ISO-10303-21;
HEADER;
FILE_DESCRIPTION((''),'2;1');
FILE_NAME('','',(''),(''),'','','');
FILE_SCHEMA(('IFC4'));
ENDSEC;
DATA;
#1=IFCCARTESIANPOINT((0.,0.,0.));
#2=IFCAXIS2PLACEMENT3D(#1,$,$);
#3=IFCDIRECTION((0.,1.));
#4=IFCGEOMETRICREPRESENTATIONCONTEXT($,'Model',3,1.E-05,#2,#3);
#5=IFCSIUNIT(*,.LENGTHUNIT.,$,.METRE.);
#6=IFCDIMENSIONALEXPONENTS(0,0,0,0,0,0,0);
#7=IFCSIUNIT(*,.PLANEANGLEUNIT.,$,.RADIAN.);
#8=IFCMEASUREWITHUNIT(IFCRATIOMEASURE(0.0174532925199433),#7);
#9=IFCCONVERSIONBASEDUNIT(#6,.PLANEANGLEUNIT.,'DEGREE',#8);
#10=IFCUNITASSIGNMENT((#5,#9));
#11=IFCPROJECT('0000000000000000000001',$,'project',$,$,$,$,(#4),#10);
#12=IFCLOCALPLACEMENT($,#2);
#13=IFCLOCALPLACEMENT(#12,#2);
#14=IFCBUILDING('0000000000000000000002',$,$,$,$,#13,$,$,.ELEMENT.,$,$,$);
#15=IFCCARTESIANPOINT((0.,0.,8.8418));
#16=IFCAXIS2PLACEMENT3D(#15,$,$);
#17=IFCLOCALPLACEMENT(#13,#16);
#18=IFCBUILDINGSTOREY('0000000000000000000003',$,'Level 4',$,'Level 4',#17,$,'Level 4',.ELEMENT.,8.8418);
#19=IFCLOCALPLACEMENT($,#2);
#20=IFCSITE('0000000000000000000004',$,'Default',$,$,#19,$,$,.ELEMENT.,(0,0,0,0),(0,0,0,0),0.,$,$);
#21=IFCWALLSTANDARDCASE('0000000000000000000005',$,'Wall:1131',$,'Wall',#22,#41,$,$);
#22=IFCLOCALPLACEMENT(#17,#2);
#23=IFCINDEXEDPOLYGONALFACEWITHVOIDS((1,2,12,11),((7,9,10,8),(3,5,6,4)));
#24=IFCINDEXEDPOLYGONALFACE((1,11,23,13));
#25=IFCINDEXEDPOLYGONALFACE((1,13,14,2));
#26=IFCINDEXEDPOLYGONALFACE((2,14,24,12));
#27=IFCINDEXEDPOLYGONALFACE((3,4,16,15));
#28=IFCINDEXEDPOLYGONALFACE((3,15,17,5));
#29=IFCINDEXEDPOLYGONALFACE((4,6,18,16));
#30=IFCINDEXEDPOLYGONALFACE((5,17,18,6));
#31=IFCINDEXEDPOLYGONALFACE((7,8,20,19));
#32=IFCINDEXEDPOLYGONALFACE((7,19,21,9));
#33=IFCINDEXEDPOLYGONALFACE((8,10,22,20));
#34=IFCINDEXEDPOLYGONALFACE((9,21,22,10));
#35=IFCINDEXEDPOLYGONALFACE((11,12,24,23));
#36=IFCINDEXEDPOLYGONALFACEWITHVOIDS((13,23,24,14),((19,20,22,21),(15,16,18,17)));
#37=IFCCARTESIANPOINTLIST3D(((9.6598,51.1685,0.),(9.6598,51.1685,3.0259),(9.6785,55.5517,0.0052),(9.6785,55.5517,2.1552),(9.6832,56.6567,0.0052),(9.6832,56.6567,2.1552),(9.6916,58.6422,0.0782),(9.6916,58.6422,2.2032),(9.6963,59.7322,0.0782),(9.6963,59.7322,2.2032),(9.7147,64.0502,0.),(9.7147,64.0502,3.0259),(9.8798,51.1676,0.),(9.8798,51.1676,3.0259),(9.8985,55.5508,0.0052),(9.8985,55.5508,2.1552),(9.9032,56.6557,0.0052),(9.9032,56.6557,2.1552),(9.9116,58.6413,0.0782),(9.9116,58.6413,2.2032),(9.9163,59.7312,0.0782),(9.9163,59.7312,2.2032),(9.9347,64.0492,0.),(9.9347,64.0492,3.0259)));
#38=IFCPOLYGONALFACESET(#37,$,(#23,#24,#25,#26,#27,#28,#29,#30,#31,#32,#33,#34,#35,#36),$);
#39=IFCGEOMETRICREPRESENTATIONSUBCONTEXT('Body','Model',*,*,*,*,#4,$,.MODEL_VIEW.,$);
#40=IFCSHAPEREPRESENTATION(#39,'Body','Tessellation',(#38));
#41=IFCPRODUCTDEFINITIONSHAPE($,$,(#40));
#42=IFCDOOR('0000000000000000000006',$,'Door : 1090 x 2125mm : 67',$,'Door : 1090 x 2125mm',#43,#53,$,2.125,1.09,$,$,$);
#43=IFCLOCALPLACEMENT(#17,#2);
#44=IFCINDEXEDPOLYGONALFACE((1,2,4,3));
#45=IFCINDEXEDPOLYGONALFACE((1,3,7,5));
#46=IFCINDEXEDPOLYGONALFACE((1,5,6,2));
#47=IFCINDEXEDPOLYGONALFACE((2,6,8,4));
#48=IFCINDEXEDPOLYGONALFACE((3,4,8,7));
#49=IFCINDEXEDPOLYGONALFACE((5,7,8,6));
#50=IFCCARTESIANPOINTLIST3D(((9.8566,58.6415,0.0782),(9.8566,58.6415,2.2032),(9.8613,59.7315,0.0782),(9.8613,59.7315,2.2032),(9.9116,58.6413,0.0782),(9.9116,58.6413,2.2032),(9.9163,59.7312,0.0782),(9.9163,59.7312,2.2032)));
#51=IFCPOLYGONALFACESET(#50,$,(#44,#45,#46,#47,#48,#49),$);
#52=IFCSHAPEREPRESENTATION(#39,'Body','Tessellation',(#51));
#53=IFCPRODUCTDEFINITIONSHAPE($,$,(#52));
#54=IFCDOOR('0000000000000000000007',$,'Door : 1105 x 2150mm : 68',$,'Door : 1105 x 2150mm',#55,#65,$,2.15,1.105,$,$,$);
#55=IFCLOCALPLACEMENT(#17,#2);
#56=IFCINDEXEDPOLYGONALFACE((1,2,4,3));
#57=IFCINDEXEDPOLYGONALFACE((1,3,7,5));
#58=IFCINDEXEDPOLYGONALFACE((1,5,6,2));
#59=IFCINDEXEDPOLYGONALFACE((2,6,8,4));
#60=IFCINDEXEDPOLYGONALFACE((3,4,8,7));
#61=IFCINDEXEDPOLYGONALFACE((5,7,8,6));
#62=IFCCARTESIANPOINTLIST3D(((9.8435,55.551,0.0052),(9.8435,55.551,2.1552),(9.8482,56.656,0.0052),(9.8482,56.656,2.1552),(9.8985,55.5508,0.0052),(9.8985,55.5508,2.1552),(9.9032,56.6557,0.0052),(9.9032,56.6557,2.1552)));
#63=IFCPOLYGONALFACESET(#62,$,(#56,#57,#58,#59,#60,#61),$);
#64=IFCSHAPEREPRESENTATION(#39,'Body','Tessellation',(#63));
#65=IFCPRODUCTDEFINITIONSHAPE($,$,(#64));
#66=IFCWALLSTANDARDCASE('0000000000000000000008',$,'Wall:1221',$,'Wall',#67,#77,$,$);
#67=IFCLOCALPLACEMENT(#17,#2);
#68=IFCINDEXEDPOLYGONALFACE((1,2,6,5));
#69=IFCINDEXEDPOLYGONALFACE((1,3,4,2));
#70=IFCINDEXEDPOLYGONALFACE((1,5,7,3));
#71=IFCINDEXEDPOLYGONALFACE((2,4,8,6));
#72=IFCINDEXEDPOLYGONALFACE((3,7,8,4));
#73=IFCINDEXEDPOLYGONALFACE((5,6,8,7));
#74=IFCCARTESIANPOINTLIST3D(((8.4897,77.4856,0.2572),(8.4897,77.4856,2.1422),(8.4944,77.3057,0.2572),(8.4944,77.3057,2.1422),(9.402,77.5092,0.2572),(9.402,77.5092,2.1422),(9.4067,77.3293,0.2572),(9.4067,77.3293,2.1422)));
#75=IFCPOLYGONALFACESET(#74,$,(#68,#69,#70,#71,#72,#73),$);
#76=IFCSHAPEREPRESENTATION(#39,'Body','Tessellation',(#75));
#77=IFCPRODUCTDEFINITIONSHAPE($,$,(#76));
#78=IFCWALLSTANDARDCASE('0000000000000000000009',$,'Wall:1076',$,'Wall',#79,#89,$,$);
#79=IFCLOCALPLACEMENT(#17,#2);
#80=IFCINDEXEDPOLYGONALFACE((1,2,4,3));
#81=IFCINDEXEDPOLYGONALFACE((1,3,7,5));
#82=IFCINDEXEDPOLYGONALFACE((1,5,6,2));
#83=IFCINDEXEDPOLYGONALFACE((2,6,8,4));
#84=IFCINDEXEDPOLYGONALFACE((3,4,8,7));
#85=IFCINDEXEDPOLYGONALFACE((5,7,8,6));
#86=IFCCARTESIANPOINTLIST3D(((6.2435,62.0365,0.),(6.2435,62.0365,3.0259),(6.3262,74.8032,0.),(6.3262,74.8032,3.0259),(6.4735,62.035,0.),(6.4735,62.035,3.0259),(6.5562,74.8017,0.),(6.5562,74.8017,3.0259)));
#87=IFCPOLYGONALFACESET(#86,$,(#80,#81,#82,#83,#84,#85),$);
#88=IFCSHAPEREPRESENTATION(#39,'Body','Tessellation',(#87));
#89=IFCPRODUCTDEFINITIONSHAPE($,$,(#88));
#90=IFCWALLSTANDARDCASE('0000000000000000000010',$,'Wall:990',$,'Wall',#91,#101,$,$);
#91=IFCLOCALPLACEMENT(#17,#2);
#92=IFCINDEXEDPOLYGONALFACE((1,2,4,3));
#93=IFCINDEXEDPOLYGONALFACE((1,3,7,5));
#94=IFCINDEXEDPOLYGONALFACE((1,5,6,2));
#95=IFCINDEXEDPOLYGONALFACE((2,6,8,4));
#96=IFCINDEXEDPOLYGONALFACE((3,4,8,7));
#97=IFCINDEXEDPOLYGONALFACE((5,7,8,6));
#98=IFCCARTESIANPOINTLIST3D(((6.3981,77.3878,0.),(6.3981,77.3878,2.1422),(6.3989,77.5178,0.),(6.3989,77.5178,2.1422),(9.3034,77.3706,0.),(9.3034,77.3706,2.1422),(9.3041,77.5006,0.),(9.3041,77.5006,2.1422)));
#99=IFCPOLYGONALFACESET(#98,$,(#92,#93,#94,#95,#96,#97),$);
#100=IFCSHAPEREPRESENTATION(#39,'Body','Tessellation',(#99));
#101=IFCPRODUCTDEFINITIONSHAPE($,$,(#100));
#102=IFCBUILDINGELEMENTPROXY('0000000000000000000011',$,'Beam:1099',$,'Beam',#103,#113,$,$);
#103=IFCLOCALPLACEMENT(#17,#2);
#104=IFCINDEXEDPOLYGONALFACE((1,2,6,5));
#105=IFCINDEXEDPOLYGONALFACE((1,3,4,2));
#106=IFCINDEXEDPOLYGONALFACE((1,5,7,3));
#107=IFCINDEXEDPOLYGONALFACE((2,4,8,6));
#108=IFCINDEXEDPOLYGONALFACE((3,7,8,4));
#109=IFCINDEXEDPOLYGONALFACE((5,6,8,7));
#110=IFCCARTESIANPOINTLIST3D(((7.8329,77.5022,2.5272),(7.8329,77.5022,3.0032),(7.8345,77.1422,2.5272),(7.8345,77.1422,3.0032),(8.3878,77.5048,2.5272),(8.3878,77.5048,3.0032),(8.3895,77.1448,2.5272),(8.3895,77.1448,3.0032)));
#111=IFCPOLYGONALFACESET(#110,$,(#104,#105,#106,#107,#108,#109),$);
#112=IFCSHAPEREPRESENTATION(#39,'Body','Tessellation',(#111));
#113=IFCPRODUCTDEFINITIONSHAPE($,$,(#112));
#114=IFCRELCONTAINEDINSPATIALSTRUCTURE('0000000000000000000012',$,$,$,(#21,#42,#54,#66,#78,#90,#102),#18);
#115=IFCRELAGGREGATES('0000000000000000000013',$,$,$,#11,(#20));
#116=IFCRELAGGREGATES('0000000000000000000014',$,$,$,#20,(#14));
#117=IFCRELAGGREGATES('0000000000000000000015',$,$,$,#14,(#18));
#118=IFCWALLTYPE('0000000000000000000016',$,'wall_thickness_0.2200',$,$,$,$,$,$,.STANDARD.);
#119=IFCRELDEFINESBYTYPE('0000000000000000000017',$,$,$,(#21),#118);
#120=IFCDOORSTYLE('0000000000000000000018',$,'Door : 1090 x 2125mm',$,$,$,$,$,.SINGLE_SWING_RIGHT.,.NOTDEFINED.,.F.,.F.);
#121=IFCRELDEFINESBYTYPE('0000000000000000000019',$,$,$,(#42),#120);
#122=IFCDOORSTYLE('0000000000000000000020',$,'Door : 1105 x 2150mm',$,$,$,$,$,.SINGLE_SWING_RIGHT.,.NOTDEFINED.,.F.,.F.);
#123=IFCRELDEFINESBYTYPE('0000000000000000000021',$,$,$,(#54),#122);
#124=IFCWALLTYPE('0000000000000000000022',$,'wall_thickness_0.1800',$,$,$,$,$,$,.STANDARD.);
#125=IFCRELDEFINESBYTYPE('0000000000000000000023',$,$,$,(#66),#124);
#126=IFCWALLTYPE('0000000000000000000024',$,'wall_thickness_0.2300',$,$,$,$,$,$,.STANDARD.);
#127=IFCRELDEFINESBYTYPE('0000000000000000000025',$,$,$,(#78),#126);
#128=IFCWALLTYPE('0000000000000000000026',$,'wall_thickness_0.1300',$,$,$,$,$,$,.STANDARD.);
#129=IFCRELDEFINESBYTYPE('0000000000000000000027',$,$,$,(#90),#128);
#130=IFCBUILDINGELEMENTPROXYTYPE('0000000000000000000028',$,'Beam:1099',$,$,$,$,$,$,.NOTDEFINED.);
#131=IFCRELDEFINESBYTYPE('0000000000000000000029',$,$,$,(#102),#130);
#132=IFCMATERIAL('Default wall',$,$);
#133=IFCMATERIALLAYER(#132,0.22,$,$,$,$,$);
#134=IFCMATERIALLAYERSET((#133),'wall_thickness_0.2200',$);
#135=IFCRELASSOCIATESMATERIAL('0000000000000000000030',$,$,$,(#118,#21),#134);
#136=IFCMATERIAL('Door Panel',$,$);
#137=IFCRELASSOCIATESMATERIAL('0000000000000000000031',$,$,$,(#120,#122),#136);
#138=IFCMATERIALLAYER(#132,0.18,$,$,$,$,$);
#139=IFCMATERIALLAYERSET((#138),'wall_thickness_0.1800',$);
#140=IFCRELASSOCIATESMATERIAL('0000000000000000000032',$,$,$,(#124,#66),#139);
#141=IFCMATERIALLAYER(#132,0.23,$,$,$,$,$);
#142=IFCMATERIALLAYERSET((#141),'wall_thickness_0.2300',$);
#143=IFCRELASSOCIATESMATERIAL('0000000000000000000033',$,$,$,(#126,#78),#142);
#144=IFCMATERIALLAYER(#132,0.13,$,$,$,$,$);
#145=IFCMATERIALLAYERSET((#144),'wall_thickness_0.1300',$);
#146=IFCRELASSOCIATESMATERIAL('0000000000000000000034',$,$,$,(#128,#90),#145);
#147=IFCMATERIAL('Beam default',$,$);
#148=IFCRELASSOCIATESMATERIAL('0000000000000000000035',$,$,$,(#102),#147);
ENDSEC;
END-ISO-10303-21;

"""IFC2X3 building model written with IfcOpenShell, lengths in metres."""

from ifc_helpers import new_model, entity, si_unit, converted_unit, direction, frame, frame_2d, origin, origin_2d_with_axis, place, context, subcontext, project, spatial, polyline, rectangle, outline, extrude, source, transform, mapped, material, layer, layer_set, layer_usage, type_object, type_shapes, element, fill, save


model = new_model("IFC2X3")

# Units and contexts
model_context = context("Model", 3, precision=1e-05, world=origin(), true_north=direction((0.0, 1.0)))
body_context = subcontext(model_context, "Body", "Model", "MODEL_VIEW")
ifc_project = project(units=[si_unit("LENGTHUNIT", "METRE"), converted_unit("PLANEANGLEUNIT", "DEGREE", entity("IfcRatioMeasure", 0.0174532925199433), si_unit("PLANEANGLEUNIT", "RADIAN"), dimensions=[0, 0, 0, 0, 0, 0, 0])], contexts=[model_context])

# Site, building, storey
site_placement = place(None, origin())
site = spatial("IfcSite", under=ifc_project, at=site_placement, Name="Default", CompositionType="ELEMENT", RefLatitude=(0, 0, 0, 0), RefLongitude=(0, 0, 0, 0), RefElevation=0.0)
placement_1 = place(None, origin())
building_placement = place(placement_1, origin())
building = spatial("IfcBuilding", under=site, at=building_placement, CompositionType="ELEMENT")
storey_placement = place(building_placement, frame((0.0, 0.0, 8.8418)))
storey = spatial("IfcBuildingStorey", under=building, at=storey_placement, Name="Level 4", ObjectType="Level 4", LongName="Level 4", CompositionType="ELEMENT", Elevation=8.8418)

# Shared definitions
ifc_material_1 = material(Name="Default wall")

# Wall, openings, doors
ifc_layer_1 = layer(ifc_material_1, 0.22)
ifc_layer_set_1 = layer_set([ifc_layer_1], Name="wall_thickness_0.2200")
ifc_layer_usage_1 = layer_usage(ifc_layer_set_1, "AXIS2", "POSITIVE", -0.11)
wall_type_1 = type_object("IfcWallType", Name="wall_thickness_0.2200", PredefinedType="STANDARD", material=ifc_layer_set_1)
wall_1_placement = place(storey_placement, frame((9.8247, 64.0497, 0.0), z_axis=(0.0, 0.0, 1.0), x_axis=(-0.004256, -0.999991, 0.0)))
wall_1 = element("IfcWallStandardCase", 1, at=wall_1_placement, inside=storey, type_object=wall_type_1, material=ifc_layer_usage_1, Name="Wall:1131", ObjectType="Wall", context=body_context, shape_type="SweptSolid", body=[
    extrude(outline(polyline([(12.8817, -0.11), (12.8817, 0.11), (0.0, 0.11), (0.0, -0.11), (12.8817, -0.11)])), origin(), (0.0, 0.0, 1.0), 3.0259),
])
opening_1_placement = place(wall_1_placement, frame((4.318, -0.11, 0.0782)))
opening_1 = element("IfcOpeningElement", 2, at=opening_1_placement, cuts=wall_1, ObjectType="Opening", context=body_context, shape_type="SweptSolid", body=[
    extrude(rectangle(XDim=1.09, YDim=2.125, at=frame_2d((1.0625, 0.545), x_axis=(0.0, 1.0))), frame((0.0, 0.0, 0.0), z_axis=(0.0, 1.0, 0.0), x_axis=(0.0, 0.0, 1.0)), (0.0, 0.0, 1.0), 0.22),
])
opening_2_placement = place(wall_1_placement, frame((7.3935, -0.11, 0.0052)))
opening_2 = element("IfcOpeningElement", 3, at=opening_2_placement, cuts=wall_1, ObjectType="Opening", context=body_context, shape_type="SweptSolid", body=[
    extrude(rectangle(XDim=1.105, YDim=2.15, at=frame_2d((1.075, 0.5525), x_axis=(0.0, 1.0))), frame((0.0, 0.0, 0.0), z_axis=(0.0, 1.0, 0.0), x_axis=(0.0, 0.0, 1.0)), (0.0, 0.0, 1.0), 0.22),
])
ifc_material_2 = material(Name="Door Panel")
door_style_1 = type_object("IfcDoorStyle", Name="Door : 1090 x 2125mm", ConstructionType="NOTDEFINED", OperationType="SINGLE_SWING_RIGHT", ParameterTakesPrecedence=False, Sizeable=False, material=ifc_material_2)
shared_shape_1 = source(origin(), body_context, "Body", "SweptSolid", [
    extrude(rectangle(XDim=0.055, YDim=1.09, at=origin_2d_with_axis()), frame((0.545, 0.1925, 0.0), z_axis=(0.0, 0.0, 1.0), x_axis=(0.0, 1.0, 0.0)), (0.0, 0.0, 1.0), 2.125),
])
type_shapes(door_style_1, [shared_shape_1])
door_1_placement = place(opening_1_placement, origin())
door_1 = element("IfcDoor", 4, at=door_1_placement, inside=storey, type_object=door_style_1, Name="Door : 1090 x 2125mm : 67", ObjectType="Door : 1090 x 2125mm", OverallHeight=2.125, OverallWidth=1.09, context=body_context, shape_type="MappedRepresentation", body=[
    mapped(shared_shape_1, transform((0.0, 0.0, 0.0), scale=1.0)),
])
fill(opening_1, door_1)
door_style_2 = type_object("IfcDoorStyle", Name="Door : 1105 x 2150mm", ConstructionType="NOTDEFINED", OperationType="SINGLE_SWING_RIGHT", ParameterTakesPrecedence=False, Sizeable=False, material=ifc_material_2)
shared_shape_2 = source(origin(), body_context, "Body", "SweptSolid", [
    extrude(rectangle(XDim=0.055, YDim=1.105, at=origin_2d_with_axis()), frame((0.5525, 0.1925, 0.0), z_axis=(0.0, 0.0, 1.0), x_axis=(0.0, 1.0, 0.0)), (0.0, 0.0, 1.0), 2.15),
])
type_shapes(door_style_2, [shared_shape_2])
door_2_placement = place(opening_2_placement, origin())
door_2 = element("IfcDoor", 5, at=door_2_placement, inside=storey, type_object=door_style_2, Name="Door : 1105 x 2150mm : 68", ObjectType="Door : 1105 x 2150mm", OverallHeight=2.15, OverallWidth=1.105, context=body_context, shape_type="MappedRepresentation", body=[
    mapped(shared_shape_2, transform((0.0, 0.0, 0.0), scale=1.0)),
])
fill(opening_2, door_2)

# Walls
ifc_layer_2 = layer(ifc_material_1, 0.18)
ifc_layer_set_2 = layer_set([ifc_layer_2], Name="wall_thickness_0.1800")
ifc_layer_usage_2 = layer_usage(ifc_layer_set_2, "AXIS2", "POSITIVE", -0.09)
wall_type_2 = type_object("IfcWallType", Name="wall_thickness_0.1800", PredefinedType="STANDARD", material=ifc_layer_set_2)
placement_2 = place(building_placement, frame((0.0, 0.0, 9.099)))
wall_2_placement = place(placement_2, frame((8.4921, 77.3957, 0.0), z_axis=(0.0, 0.0, 1.0), x_axis=(0.999666, 0.025825, 0.0)))
element("IfcWallStandardCase", 6, at=wall_2_placement, inside=storey, type_object=wall_type_2, material=ifc_layer_usage_2, Name="Wall:1221", ObjectType="Wall", context=body_context, shape_type="SweptSolid", body=[
    extrude(outline(polyline([(0.9126, -0.09), (0.9126, 0.09), (0.0, 0.09), (0.0, -0.09), (0.9126, -0.09)])), origin(), (0.0, 0.0, 1.0), 1.885),
])
ifc_layer_3 = layer(ifc_material_1, 0.23)
ifc_layer_set_3 = layer_set([ifc_layer_3], Name="wall_thickness_0.2300")
ifc_layer_usage_3 = layer_usage(ifc_layer_set_3, "AXIS2", "POSITIVE", -0.115)
wall_type_3 = type_object("IfcWallType", Name="wall_thickness_0.2300", PredefinedType="STANDARD", material=ifc_layer_set_3)
wall_3_placement = place(storey_placement, frame((6.4412, 74.8024, 0.0), z_axis=(0.0, 0.0, 1.0), x_axis=(-0.006481, -0.999979, 0.0)))
element("IfcWallStandardCase", 7, at=wall_3_placement, inside=storey, type_object=wall_type_3, material=ifc_layer_usage_3, Name="Wall:1076", ObjectType="Wall", context=body_context, shape_type="SweptSolid", body=[
    extrude(outline(polyline([(12.7669, -0.115), (12.7669, 0.115), (0.0, 0.115), (0.0, -0.115), (12.7669, -0.115)])), origin(), (0.0, 0.0, 1.0), 3.0259),
])
ifc_layer_4 = layer(ifc_material_1, 0.13)
ifc_layer_set_4 = layer_set([ifc_layer_4], Name="wall_thickness_0.1300")
ifc_layer_usage_4 = layer_usage(ifc_layer_set_4, "AXIS2", "POSITIVE", -0.065)
wall_type_4 = type_object("IfcWallType", Name="wall_thickness_0.1300", PredefinedType="STANDARD", material=ifc_layer_set_4)
wall_4_placement = place(storey_placement, frame((6.3985, 77.4528, 0.0), z_axis=(0.0, 0.0, 1.0), x_axis=(0.999982, -0.005951, 0.0)))
element("IfcWallStandardCase", 8, at=wall_4_placement, inside=storey, type_object=wall_type_4, material=ifc_layer_usage_4, Name="Wall:990", ObjectType="Wall", context=body_context, shape_type="SweptSolid", body=[
    extrude(outline(polyline([(2.9053, -0.065), (2.9053, 0.065), (0.0, 0.065), (0.0, -0.065), (2.9053, -0.065)])), origin(), (0.0, 0.0, 1.0), 2.1422),
])

# Building element proxy
ifc_material_3 = material(Name="Beam default")
building_element_proxy_type = type_object("IfcBuildingElementProxyType", Name="Beam:1099", PredefinedType="NOTDEFINED")
shared_shape_3 = source(origin(), body_context, "Body", "SweptSolid", [
    extrude(outline(polyline([(0.555, -0.18), (0.555, 0.18), (0.0, 0.18), (0.0, -0.18), (0.555, -0.18)])), origin(), (0.0, 0.0, 1.0), 0.476),
])
type_shapes(building_element_proxy_type, [shared_shape_3])
placement_3 = place(building_placement, frame((0.0, 0.0, 11.369)))
proxy_placement = place(placement_3, frame((7.8337, 77.3222, 0.0), z_axis=(0.0, 0.0, 1.0), x_axis=(0.999989, 0.004646, 0.0)))
element("IfcBuildingElementProxy", 9, at=proxy_placement, inside=storey, type_object=building_element_proxy_type, material=ifc_material_3, Name="Beam:1099", ObjectType="Beam", context=body_context, shape_type="MappedRepresentation", body=[
    mapped(shared_shape_3, transform((0.0, 0.0, 0.0), scale=1.0)),
])

save(model, "model.ifc")
